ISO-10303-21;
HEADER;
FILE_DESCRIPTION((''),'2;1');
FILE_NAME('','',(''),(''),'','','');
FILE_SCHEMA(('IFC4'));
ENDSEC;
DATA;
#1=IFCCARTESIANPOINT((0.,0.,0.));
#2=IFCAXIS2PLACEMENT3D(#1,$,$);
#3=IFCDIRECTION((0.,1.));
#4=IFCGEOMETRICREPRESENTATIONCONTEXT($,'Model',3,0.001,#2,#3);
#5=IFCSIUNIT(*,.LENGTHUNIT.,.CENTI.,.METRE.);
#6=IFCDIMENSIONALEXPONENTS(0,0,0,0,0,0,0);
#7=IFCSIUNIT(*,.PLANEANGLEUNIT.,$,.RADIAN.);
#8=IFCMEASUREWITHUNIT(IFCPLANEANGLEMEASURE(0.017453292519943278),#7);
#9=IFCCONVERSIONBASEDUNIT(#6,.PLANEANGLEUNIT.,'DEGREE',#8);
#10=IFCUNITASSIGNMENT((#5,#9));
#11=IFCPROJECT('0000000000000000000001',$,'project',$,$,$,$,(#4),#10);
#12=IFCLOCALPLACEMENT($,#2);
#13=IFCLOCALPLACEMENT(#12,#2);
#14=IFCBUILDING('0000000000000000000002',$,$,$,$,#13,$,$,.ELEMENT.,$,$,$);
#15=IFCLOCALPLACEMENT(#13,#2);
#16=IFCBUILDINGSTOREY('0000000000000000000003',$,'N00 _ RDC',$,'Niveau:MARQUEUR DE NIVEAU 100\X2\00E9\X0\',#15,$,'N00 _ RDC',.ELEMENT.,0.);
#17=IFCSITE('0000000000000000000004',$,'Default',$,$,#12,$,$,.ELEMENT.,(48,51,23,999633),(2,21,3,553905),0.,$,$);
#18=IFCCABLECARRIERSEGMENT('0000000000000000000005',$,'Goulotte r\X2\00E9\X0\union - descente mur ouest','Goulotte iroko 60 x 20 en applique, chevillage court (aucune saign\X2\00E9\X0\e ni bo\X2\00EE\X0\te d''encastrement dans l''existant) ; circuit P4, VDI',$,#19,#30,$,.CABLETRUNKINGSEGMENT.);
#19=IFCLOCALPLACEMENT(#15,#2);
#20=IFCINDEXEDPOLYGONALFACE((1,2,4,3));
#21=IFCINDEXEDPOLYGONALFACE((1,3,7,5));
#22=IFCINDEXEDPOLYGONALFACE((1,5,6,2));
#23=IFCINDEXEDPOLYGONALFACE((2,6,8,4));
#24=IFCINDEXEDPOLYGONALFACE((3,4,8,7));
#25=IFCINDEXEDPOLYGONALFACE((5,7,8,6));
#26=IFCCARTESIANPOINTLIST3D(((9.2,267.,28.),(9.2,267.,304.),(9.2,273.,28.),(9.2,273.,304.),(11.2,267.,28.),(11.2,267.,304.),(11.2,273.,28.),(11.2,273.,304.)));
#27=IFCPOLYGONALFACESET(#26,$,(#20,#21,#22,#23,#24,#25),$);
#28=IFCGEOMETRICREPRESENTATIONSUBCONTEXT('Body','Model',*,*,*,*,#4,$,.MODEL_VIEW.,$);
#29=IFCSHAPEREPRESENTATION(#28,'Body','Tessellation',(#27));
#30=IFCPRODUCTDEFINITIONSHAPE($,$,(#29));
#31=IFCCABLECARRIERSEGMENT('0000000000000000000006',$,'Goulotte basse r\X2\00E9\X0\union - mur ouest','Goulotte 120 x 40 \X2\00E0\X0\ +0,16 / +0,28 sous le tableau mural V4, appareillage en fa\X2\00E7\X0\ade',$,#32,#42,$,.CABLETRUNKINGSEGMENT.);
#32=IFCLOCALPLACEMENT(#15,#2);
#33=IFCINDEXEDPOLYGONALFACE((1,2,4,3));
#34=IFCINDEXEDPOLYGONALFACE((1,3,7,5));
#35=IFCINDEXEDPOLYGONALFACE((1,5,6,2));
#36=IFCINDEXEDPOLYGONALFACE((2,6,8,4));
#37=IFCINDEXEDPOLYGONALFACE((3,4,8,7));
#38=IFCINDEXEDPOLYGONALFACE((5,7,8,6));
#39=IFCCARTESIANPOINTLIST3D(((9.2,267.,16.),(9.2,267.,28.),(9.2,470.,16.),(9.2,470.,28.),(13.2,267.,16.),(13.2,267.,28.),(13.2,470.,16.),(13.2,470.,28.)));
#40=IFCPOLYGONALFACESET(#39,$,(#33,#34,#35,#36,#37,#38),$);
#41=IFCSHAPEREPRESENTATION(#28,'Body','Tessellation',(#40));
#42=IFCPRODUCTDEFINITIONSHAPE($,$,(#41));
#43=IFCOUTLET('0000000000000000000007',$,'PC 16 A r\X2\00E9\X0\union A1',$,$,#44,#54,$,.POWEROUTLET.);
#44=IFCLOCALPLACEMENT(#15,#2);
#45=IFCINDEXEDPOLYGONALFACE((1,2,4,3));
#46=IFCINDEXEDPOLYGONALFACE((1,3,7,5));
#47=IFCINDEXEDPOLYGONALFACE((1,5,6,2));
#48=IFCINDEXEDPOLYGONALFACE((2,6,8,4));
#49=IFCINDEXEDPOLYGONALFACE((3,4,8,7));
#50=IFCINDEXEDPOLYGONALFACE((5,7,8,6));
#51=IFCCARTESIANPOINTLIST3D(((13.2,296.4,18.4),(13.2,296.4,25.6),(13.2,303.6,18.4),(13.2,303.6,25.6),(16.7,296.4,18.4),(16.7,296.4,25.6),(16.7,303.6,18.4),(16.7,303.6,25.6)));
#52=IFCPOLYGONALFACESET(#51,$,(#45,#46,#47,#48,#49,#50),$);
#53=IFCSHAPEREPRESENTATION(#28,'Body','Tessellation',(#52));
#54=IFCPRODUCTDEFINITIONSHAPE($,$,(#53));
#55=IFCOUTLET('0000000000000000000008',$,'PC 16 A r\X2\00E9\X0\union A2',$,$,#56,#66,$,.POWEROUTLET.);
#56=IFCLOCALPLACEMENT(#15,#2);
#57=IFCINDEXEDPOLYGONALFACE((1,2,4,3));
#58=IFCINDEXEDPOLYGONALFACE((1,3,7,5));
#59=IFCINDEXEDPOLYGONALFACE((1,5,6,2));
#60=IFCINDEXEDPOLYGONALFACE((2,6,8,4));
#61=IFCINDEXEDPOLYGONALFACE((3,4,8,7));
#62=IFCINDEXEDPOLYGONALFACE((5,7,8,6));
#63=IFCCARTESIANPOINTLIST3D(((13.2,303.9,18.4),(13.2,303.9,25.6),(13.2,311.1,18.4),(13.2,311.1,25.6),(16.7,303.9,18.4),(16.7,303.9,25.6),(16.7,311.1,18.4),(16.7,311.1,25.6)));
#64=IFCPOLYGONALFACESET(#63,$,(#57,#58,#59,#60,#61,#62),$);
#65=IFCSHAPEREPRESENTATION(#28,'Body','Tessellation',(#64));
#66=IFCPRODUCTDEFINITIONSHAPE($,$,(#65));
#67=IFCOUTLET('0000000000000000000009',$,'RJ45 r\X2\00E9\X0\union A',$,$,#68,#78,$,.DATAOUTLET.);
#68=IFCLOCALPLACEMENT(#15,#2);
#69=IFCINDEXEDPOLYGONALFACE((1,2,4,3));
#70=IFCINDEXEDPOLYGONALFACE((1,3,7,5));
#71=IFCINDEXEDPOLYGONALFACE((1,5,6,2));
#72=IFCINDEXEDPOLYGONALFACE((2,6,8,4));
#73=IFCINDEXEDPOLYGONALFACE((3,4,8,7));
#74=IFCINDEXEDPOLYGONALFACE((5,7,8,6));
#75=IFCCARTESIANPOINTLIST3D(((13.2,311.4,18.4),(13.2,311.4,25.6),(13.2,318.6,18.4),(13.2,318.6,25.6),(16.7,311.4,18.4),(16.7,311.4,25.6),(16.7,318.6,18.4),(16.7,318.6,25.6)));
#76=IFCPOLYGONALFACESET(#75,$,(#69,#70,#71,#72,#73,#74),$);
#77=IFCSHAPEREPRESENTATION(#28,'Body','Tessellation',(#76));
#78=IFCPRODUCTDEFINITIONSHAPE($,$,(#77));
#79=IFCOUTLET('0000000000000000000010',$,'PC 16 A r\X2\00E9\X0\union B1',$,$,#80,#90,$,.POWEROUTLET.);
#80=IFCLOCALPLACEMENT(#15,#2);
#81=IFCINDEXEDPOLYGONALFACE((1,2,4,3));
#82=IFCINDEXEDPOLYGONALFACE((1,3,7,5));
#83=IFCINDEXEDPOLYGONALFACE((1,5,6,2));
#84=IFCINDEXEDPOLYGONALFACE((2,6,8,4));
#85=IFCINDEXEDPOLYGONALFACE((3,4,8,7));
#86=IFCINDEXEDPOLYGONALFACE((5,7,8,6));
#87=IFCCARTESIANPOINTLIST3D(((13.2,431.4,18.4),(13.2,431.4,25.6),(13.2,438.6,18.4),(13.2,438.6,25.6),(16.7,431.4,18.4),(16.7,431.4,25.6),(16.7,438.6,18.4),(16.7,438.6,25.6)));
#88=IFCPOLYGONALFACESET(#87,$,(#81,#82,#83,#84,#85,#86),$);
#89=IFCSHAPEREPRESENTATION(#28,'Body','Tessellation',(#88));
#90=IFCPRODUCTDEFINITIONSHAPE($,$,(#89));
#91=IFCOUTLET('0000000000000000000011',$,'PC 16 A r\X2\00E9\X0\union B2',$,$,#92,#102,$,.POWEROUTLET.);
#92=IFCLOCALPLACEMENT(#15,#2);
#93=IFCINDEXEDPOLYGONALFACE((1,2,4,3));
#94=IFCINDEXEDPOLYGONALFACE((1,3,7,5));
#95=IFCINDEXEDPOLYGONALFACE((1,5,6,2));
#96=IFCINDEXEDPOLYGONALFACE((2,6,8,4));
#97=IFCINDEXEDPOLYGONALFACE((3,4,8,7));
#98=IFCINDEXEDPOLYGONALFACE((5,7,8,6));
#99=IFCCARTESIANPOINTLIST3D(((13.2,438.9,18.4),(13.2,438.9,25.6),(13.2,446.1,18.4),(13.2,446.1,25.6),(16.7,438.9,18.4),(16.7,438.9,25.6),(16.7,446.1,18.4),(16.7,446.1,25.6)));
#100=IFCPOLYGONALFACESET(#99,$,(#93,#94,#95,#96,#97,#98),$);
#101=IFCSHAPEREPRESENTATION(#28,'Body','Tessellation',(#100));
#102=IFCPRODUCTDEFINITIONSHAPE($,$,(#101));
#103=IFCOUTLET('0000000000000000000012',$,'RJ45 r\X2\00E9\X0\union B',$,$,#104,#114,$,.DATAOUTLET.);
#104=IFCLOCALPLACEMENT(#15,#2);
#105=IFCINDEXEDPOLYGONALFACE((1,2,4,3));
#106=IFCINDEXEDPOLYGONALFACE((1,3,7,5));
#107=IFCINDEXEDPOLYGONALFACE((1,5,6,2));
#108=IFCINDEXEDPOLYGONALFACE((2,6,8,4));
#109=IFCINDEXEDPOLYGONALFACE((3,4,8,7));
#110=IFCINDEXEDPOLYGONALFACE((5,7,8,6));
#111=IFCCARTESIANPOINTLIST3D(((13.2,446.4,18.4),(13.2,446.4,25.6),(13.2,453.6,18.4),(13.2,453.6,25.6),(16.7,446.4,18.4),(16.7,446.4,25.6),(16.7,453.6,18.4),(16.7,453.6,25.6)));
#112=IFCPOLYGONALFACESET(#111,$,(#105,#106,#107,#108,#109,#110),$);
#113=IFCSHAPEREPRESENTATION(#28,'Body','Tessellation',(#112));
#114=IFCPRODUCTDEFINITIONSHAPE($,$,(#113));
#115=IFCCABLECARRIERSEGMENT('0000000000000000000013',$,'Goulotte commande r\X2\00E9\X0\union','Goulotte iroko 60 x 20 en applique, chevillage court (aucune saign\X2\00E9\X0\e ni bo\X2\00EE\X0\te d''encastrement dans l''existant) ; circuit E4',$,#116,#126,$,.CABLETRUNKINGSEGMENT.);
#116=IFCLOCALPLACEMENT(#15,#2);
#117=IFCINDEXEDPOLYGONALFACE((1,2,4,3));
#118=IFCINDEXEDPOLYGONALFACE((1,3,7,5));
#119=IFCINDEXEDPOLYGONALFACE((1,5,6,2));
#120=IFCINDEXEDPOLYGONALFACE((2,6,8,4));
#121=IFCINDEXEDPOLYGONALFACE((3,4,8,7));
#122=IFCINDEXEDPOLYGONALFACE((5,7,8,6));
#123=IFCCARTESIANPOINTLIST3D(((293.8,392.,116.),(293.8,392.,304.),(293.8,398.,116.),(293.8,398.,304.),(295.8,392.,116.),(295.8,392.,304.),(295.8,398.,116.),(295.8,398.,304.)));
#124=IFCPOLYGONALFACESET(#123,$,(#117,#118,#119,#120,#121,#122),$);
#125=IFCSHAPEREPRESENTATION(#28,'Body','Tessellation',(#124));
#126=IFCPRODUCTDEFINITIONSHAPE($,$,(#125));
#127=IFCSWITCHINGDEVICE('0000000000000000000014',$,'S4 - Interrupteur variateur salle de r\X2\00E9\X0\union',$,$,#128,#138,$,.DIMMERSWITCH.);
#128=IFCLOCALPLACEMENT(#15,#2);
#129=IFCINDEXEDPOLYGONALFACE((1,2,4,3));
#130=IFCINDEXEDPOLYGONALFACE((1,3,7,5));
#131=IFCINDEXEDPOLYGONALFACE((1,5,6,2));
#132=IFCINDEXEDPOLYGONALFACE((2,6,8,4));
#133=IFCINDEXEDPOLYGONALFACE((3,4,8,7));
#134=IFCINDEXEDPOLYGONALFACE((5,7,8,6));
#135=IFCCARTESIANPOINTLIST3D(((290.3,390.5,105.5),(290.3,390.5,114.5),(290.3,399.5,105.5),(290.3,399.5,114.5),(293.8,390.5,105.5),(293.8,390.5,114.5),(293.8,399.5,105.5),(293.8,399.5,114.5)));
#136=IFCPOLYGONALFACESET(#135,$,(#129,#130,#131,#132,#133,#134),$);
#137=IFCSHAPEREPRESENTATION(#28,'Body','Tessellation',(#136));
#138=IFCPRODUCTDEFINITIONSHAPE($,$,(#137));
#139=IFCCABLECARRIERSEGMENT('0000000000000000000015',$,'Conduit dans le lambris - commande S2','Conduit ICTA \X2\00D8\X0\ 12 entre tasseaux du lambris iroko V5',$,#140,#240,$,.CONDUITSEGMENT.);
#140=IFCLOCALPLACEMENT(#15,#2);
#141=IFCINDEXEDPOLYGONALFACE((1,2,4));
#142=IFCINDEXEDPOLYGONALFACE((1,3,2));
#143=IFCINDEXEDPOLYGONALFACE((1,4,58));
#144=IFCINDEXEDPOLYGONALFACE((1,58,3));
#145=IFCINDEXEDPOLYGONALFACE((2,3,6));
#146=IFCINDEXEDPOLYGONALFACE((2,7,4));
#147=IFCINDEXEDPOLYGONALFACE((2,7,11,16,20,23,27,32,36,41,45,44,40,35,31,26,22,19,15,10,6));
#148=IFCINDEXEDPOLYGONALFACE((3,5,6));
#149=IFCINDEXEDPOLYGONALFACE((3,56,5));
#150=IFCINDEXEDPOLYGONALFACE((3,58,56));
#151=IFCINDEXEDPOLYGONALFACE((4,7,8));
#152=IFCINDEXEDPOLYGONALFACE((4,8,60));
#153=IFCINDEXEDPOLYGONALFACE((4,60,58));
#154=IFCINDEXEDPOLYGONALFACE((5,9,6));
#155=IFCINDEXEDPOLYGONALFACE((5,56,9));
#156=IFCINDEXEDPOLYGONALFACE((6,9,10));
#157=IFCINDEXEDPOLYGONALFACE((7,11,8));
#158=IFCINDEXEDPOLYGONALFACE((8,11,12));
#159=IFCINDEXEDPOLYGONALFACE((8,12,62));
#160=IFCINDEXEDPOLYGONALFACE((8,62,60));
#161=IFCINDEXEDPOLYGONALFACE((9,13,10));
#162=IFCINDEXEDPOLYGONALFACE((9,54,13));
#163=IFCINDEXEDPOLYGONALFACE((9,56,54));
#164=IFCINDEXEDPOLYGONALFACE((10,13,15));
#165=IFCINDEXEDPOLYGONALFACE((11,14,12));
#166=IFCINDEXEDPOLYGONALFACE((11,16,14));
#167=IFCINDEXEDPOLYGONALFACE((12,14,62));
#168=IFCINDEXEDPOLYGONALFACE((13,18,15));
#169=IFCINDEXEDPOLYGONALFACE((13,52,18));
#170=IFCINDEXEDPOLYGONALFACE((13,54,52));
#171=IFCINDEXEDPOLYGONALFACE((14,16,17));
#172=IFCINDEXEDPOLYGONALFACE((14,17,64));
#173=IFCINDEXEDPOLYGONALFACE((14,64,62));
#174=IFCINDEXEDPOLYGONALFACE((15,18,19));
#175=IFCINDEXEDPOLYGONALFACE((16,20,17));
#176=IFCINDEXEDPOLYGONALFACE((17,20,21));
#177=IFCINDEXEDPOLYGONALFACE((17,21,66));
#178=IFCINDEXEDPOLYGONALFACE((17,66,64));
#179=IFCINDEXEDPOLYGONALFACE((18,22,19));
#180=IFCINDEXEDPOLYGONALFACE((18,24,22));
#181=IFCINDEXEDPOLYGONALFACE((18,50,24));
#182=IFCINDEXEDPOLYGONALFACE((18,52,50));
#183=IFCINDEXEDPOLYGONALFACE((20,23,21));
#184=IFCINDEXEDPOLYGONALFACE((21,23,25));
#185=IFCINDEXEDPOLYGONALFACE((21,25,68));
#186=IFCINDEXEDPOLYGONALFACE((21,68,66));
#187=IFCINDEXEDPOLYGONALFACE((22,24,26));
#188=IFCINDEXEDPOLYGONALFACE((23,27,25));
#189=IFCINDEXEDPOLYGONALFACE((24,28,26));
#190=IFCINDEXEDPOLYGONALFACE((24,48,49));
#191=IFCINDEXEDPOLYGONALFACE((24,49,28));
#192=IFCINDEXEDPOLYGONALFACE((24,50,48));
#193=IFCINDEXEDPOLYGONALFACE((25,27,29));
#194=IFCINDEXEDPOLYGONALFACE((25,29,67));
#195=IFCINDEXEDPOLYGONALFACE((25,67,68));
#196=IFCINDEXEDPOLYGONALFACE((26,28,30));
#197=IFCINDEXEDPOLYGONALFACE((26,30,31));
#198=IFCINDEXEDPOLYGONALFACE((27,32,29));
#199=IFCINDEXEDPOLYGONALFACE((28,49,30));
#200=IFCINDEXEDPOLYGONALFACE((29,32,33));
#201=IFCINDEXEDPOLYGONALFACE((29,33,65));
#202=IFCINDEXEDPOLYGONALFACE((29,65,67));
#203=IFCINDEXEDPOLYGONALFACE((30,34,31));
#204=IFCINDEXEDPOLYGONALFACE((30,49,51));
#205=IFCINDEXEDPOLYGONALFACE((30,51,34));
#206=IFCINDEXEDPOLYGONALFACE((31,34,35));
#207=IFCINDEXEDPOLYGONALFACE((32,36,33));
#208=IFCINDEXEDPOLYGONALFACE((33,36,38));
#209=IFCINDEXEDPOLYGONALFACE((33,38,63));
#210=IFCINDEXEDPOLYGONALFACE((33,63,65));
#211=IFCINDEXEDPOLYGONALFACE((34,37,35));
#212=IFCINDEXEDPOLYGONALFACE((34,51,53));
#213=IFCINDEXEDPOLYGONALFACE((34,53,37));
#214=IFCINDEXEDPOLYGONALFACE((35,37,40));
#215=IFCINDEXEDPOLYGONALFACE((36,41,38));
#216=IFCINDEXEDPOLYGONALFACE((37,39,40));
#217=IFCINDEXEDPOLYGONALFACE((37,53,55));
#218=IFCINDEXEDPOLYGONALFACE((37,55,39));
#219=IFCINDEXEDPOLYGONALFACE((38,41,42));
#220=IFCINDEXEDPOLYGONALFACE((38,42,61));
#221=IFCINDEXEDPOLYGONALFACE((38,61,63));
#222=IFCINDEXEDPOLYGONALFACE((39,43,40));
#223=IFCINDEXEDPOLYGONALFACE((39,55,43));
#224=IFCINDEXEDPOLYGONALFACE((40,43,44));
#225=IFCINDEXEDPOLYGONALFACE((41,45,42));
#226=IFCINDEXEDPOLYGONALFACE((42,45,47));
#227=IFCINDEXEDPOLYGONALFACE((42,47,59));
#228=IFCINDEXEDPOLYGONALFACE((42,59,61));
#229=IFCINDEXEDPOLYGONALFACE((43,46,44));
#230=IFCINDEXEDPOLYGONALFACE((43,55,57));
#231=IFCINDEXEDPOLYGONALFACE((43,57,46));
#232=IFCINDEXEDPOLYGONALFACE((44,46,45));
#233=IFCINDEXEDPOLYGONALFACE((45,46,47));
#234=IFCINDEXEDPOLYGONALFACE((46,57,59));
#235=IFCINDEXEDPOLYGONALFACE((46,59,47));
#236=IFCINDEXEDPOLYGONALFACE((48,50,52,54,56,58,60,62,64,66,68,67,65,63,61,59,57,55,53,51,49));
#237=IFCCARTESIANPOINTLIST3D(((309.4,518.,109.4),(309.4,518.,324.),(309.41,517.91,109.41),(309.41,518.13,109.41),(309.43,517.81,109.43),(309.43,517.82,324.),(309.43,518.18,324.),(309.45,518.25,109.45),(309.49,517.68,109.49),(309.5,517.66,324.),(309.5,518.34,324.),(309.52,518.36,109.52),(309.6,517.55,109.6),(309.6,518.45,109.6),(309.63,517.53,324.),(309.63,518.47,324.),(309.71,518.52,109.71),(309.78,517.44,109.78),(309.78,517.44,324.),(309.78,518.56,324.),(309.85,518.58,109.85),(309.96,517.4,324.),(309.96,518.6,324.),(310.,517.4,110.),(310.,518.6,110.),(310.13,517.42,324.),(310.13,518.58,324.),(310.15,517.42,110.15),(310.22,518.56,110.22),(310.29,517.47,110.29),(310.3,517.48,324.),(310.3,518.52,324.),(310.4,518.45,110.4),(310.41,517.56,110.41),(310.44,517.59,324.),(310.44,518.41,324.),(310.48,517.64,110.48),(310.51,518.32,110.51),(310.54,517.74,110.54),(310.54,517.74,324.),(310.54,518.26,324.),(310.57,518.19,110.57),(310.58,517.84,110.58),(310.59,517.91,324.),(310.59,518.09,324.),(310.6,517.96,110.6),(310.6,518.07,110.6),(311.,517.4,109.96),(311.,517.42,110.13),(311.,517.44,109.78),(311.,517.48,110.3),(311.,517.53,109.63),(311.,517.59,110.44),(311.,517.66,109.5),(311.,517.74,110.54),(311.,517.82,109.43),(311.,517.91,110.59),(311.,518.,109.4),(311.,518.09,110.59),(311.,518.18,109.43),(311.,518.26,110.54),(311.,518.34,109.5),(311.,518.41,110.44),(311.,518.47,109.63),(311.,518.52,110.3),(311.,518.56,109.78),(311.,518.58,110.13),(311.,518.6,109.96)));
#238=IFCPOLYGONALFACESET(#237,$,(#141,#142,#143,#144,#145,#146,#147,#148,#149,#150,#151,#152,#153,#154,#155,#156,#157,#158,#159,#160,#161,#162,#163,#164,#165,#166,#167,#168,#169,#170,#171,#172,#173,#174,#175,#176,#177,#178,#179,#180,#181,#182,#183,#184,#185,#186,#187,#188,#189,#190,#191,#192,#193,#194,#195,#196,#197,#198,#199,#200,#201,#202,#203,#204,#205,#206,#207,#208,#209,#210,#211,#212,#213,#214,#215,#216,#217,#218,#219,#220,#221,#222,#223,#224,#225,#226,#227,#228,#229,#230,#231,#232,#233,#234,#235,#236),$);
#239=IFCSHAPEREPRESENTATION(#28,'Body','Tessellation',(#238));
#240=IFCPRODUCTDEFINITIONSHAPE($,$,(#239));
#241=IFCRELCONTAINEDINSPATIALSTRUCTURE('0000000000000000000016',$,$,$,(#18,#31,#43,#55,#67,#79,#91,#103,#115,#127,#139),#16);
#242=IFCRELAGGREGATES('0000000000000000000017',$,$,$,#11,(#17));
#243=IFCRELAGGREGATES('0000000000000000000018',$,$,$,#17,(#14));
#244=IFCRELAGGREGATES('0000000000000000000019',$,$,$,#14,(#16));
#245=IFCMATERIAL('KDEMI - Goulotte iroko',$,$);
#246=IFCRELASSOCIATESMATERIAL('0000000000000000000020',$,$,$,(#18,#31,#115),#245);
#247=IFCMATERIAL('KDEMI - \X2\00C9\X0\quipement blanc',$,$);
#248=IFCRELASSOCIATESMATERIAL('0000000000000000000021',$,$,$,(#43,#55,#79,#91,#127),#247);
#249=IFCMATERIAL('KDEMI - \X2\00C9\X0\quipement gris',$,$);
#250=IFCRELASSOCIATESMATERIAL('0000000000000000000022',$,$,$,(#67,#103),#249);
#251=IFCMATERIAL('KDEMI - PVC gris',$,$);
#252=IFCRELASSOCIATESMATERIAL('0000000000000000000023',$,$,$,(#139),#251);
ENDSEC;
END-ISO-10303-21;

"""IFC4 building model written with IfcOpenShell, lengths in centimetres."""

from ifc_helpers import new_model, entity, si_unit, converted_unit, direction, frame, frame_2d, origin, origin_with_axes, place, context, subcontext, project, spatial, rectangle, extrude, material, element, save


model = new_model("IFC4")

# Units and contexts
model_context = context("Model", 3, precision=0.001, world=origin(), true_north=direction((0.0, 1.0)))
body_context = subcontext(model_context, "Body", "Model", "MODEL_VIEW")
ifc_project = project(units=[si_unit("LENGTHUNIT", "METRE", prefix="CENTI"), converted_unit("PLANEANGLEUNIT", "DEGREE", entity("IfcPlaneAngleMeasure", 0.017453292519943278), si_unit("PLANEANGLEUNIT", "RADIAN"), dimensions=[0, 0, 0, 0, 0, 0, 0])], contexts=[model_context])

# Site, building, storey
site_placement = place(None, origin())
site = spatial("IfcSite", under=ifc_project, at=site_placement, Name="Default", CompositionType="ELEMENT", RefLatitude=(48, 51, 23, 999633), RefLongitude=(2, 21, 3, 553905), RefElevation=0.0)
building_placement = place(site_placement, origin())
building = spatial("IfcBuilding", under=site, at=building_placement, CompositionType="ELEMENT")
storey_placement = place(building_placement, origin())
storey = spatial("IfcBuildingStorey", under=building, at=storey_placement, Name="N00 _ RDC", ObjectType="Niveau:MARQUEUR DE NIVEAU 100é", LongName="N00 _ RDC", CompositionType="ELEMENT", Elevation=0.0)

# Shared definitions
ifc_material_1 = material(Name="KDEMI - PVC gris")
ifc_material_2 = material(Name="KDEMI - Goulotte iroko")

# Shared definitions
ifc_material_3 = material(Name="KDEMI - Équipement blanc")

# Cable carrier segments
cable_carrier_segment_1_placement = place(storey_placement, origin_with_axes())
element("IfcCableCarrierSegment", 1, at=cable_carrier_segment_1_placement, inside=storey, material=ifc_material_2, Name="Goulotte réunion - descente mur ouest", Description="Goulotte iroko 60 x 20 en applique, chevillage court (aucune saignée ni boîte d'encastrement dans l'existant) ; circuit P4, VDI", PredefinedType="CABLETRUNKINGSEGMENT", context=body_context, shape_type="SweptSolid", body=[
    extrude(rectangle(XDim=2.0, YDim=6.0, at=frame_2d((10.2, 270.0))), frame((0.0, 0.0, 28.0)), (0.0, 0.0, 1.0), 276.0),
])
cable_carrier_segment_2_placement = place(storey_placement, origin_with_axes())
element("IfcCableCarrierSegment", 2, at=cable_carrier_segment_2_placement, inside=storey, material=ifc_material_2, Name="Goulotte basse réunion - mur ouest", Description="Goulotte 120 x 40 à +0,16 / +0,28 sous le tableau mural V4, appareillage en façade", PredefinedType="CABLETRUNKINGSEGMENT", context=body_context, shape_type="SweptSolid", body=[
    extrude(rectangle(XDim=4.0, YDim=203.0, at=frame_2d((11.2, 368.5))), frame((0.0, 0.0, 16.0)), (0.0, 0.0, 1.0), 12.0),
])

# Outlets
outlet_1_placement = place(storey_placement, origin_with_axes())
element("IfcOutlet", 3, at=outlet_1_placement, inside=storey, material=ifc_material_3, Name="PC 16 A réunion A1", PredefinedType="POWEROUTLET", context=body_context, shape_type="SweptSolid", body=[
    extrude(rectangle(XDim=3.5, YDim=7.2, at=frame_2d((14.95, 300.0))), frame((0.0, 0.0, 18.4)), (0.0, 0.0, 1.0), 7.2),
])
outlet_2_placement = place(storey_placement, origin_with_axes())
element("IfcOutlet", 4, at=outlet_2_placement, inside=storey, material=ifc_material_3, Name="PC 16 A réunion A2", PredefinedType="POWEROUTLET", context=body_context, shape_type="SweptSolid", body=[
    extrude(rectangle(XDim=3.5, YDim=7.2, at=frame_2d((14.95, 307.5))), frame((0.0, 0.0, 18.4)), (0.0, 0.0, 1.0), 7.2),
])
ifc_material_4 = material(Name="KDEMI - Équipement gris")
outlet_3_placement = place(storey_placement, origin_with_axes())
element("IfcOutlet", 5, at=outlet_3_placement, inside=storey, material=ifc_material_4, Name="RJ45 réunion A", PredefinedType="DATAOUTLET", context=body_context, shape_type="SweptSolid", body=[
    extrude(rectangle(XDim=3.5, YDim=7.2, at=frame_2d((14.95, 315.0))), frame((0.0, 0.0, 18.4)), (0.0, 0.0, 1.0), 7.2),
])
outlet_4_placement = place(storey_placement, origin_with_axes())
element("IfcOutlet", 6, at=outlet_4_placement, inside=storey, material=ifc_material_3, Name="PC 16 A réunion B1", PredefinedType="POWEROUTLET", context=body_context, shape_type="SweptSolid", body=[
    extrude(rectangle(XDim=3.5, YDim=7.2, at=frame_2d((14.95, 435.0))), frame((0.0, 0.0, 18.4)), (0.0, 0.0, 1.0), 7.2),
])
outlet_5_placement = place(storey_placement, origin_with_axes())
element("IfcOutlet", 7, at=outlet_5_placement, inside=storey, material=ifc_material_3, Name="PC 16 A réunion B2", PredefinedType="POWEROUTLET", context=body_context, shape_type="SweptSolid", body=[
    extrude(rectangle(XDim=3.5, YDim=7.2, at=frame_2d((14.95, 442.5))), frame((0.0, 0.0, 18.4)), (0.0, 0.0, 1.0), 7.2),
])
outlet_6_placement = place(storey_placement, origin_with_axes())
element("IfcOutlet", 8, at=outlet_6_placement, inside=storey, material=ifc_material_4, Name="RJ45 réunion B", PredefinedType="DATAOUTLET", context=body_context, shape_type="SweptSolid", body=[
    extrude(rectangle(XDim=3.5, YDim=7.2, at=frame_2d((14.95, 450.0))), frame((0.0, 0.0, 18.4)), (0.0, 0.0, 1.0), 7.2),
])

# Cable carrier segment
cable_carrier_segment_3_placement = place(storey_placement, origin_with_axes())
element("IfcCableCarrierSegment", 9, at=cable_carrier_segment_3_placement, inside=storey, material=ifc_material_2, Name="Goulotte commande réunion", Description="Goulotte iroko 60 x 20 en applique, chevillage court (aucune saignée ni boîte d'encastrement dans l'existant) ; circuit E4", PredefinedType="CABLETRUNKINGSEGMENT", context=body_context, shape_type="SweptSolid", body=[
    extrude(rectangle(XDim=2.0, YDim=6.0, at=frame_2d((294.8, 395.0))), frame((0.0, 0.0, 116.0)), (0.0, 0.0, 1.0), 188.0),
])

# Switching device
switching_device_1_placement = place(storey_placement, origin_with_axes())
element("IfcSwitchingDevice", 10, at=switching_device_1_placement, inside=storey, material=ifc_material_3, Name="S4 - Interrupteur variateur salle de réunion", PredefinedType="DIMMERSWITCH", context=body_context, shape_type="SweptSolid", body=[
    extrude(rectangle(XDim=3.5, YDim=9.0, at=frame_2d((292.05, 395.0))), frame((0.0, 0.0, 105.5)), (0.0, 0.0, 1.0), 9.0),
])

# Cable carrier segment
cable_carrier_segment_4_placement = place(storey_placement, origin_with_axes())
element("IfcCableCarrierSegment", 11, at=cable_carrier_segment_4_placement, inside=storey, material=ifc_material_1, Name="Conduit dans le lambris - commande S2", Description="Conduit ICTA Ø 12 entre tasseaux du lambris iroko V5", PredefinedType="CONDUITSEGMENT", context=body_context, shape_type="AdvancedSweptSolid", body=[
    entity("IfcSweptDiskSolid", entity("IfcPolyline", [entity("IfcCartesianPoint", [310.0, 518.0, 324.0]), entity("IfcCartesianPoint", [310.0, 518.0, 110.0]), entity("IfcCartesianPoint", [311.0, 518.0, 110.0])]), 0.6),
])

save(model, "model.ifc")
